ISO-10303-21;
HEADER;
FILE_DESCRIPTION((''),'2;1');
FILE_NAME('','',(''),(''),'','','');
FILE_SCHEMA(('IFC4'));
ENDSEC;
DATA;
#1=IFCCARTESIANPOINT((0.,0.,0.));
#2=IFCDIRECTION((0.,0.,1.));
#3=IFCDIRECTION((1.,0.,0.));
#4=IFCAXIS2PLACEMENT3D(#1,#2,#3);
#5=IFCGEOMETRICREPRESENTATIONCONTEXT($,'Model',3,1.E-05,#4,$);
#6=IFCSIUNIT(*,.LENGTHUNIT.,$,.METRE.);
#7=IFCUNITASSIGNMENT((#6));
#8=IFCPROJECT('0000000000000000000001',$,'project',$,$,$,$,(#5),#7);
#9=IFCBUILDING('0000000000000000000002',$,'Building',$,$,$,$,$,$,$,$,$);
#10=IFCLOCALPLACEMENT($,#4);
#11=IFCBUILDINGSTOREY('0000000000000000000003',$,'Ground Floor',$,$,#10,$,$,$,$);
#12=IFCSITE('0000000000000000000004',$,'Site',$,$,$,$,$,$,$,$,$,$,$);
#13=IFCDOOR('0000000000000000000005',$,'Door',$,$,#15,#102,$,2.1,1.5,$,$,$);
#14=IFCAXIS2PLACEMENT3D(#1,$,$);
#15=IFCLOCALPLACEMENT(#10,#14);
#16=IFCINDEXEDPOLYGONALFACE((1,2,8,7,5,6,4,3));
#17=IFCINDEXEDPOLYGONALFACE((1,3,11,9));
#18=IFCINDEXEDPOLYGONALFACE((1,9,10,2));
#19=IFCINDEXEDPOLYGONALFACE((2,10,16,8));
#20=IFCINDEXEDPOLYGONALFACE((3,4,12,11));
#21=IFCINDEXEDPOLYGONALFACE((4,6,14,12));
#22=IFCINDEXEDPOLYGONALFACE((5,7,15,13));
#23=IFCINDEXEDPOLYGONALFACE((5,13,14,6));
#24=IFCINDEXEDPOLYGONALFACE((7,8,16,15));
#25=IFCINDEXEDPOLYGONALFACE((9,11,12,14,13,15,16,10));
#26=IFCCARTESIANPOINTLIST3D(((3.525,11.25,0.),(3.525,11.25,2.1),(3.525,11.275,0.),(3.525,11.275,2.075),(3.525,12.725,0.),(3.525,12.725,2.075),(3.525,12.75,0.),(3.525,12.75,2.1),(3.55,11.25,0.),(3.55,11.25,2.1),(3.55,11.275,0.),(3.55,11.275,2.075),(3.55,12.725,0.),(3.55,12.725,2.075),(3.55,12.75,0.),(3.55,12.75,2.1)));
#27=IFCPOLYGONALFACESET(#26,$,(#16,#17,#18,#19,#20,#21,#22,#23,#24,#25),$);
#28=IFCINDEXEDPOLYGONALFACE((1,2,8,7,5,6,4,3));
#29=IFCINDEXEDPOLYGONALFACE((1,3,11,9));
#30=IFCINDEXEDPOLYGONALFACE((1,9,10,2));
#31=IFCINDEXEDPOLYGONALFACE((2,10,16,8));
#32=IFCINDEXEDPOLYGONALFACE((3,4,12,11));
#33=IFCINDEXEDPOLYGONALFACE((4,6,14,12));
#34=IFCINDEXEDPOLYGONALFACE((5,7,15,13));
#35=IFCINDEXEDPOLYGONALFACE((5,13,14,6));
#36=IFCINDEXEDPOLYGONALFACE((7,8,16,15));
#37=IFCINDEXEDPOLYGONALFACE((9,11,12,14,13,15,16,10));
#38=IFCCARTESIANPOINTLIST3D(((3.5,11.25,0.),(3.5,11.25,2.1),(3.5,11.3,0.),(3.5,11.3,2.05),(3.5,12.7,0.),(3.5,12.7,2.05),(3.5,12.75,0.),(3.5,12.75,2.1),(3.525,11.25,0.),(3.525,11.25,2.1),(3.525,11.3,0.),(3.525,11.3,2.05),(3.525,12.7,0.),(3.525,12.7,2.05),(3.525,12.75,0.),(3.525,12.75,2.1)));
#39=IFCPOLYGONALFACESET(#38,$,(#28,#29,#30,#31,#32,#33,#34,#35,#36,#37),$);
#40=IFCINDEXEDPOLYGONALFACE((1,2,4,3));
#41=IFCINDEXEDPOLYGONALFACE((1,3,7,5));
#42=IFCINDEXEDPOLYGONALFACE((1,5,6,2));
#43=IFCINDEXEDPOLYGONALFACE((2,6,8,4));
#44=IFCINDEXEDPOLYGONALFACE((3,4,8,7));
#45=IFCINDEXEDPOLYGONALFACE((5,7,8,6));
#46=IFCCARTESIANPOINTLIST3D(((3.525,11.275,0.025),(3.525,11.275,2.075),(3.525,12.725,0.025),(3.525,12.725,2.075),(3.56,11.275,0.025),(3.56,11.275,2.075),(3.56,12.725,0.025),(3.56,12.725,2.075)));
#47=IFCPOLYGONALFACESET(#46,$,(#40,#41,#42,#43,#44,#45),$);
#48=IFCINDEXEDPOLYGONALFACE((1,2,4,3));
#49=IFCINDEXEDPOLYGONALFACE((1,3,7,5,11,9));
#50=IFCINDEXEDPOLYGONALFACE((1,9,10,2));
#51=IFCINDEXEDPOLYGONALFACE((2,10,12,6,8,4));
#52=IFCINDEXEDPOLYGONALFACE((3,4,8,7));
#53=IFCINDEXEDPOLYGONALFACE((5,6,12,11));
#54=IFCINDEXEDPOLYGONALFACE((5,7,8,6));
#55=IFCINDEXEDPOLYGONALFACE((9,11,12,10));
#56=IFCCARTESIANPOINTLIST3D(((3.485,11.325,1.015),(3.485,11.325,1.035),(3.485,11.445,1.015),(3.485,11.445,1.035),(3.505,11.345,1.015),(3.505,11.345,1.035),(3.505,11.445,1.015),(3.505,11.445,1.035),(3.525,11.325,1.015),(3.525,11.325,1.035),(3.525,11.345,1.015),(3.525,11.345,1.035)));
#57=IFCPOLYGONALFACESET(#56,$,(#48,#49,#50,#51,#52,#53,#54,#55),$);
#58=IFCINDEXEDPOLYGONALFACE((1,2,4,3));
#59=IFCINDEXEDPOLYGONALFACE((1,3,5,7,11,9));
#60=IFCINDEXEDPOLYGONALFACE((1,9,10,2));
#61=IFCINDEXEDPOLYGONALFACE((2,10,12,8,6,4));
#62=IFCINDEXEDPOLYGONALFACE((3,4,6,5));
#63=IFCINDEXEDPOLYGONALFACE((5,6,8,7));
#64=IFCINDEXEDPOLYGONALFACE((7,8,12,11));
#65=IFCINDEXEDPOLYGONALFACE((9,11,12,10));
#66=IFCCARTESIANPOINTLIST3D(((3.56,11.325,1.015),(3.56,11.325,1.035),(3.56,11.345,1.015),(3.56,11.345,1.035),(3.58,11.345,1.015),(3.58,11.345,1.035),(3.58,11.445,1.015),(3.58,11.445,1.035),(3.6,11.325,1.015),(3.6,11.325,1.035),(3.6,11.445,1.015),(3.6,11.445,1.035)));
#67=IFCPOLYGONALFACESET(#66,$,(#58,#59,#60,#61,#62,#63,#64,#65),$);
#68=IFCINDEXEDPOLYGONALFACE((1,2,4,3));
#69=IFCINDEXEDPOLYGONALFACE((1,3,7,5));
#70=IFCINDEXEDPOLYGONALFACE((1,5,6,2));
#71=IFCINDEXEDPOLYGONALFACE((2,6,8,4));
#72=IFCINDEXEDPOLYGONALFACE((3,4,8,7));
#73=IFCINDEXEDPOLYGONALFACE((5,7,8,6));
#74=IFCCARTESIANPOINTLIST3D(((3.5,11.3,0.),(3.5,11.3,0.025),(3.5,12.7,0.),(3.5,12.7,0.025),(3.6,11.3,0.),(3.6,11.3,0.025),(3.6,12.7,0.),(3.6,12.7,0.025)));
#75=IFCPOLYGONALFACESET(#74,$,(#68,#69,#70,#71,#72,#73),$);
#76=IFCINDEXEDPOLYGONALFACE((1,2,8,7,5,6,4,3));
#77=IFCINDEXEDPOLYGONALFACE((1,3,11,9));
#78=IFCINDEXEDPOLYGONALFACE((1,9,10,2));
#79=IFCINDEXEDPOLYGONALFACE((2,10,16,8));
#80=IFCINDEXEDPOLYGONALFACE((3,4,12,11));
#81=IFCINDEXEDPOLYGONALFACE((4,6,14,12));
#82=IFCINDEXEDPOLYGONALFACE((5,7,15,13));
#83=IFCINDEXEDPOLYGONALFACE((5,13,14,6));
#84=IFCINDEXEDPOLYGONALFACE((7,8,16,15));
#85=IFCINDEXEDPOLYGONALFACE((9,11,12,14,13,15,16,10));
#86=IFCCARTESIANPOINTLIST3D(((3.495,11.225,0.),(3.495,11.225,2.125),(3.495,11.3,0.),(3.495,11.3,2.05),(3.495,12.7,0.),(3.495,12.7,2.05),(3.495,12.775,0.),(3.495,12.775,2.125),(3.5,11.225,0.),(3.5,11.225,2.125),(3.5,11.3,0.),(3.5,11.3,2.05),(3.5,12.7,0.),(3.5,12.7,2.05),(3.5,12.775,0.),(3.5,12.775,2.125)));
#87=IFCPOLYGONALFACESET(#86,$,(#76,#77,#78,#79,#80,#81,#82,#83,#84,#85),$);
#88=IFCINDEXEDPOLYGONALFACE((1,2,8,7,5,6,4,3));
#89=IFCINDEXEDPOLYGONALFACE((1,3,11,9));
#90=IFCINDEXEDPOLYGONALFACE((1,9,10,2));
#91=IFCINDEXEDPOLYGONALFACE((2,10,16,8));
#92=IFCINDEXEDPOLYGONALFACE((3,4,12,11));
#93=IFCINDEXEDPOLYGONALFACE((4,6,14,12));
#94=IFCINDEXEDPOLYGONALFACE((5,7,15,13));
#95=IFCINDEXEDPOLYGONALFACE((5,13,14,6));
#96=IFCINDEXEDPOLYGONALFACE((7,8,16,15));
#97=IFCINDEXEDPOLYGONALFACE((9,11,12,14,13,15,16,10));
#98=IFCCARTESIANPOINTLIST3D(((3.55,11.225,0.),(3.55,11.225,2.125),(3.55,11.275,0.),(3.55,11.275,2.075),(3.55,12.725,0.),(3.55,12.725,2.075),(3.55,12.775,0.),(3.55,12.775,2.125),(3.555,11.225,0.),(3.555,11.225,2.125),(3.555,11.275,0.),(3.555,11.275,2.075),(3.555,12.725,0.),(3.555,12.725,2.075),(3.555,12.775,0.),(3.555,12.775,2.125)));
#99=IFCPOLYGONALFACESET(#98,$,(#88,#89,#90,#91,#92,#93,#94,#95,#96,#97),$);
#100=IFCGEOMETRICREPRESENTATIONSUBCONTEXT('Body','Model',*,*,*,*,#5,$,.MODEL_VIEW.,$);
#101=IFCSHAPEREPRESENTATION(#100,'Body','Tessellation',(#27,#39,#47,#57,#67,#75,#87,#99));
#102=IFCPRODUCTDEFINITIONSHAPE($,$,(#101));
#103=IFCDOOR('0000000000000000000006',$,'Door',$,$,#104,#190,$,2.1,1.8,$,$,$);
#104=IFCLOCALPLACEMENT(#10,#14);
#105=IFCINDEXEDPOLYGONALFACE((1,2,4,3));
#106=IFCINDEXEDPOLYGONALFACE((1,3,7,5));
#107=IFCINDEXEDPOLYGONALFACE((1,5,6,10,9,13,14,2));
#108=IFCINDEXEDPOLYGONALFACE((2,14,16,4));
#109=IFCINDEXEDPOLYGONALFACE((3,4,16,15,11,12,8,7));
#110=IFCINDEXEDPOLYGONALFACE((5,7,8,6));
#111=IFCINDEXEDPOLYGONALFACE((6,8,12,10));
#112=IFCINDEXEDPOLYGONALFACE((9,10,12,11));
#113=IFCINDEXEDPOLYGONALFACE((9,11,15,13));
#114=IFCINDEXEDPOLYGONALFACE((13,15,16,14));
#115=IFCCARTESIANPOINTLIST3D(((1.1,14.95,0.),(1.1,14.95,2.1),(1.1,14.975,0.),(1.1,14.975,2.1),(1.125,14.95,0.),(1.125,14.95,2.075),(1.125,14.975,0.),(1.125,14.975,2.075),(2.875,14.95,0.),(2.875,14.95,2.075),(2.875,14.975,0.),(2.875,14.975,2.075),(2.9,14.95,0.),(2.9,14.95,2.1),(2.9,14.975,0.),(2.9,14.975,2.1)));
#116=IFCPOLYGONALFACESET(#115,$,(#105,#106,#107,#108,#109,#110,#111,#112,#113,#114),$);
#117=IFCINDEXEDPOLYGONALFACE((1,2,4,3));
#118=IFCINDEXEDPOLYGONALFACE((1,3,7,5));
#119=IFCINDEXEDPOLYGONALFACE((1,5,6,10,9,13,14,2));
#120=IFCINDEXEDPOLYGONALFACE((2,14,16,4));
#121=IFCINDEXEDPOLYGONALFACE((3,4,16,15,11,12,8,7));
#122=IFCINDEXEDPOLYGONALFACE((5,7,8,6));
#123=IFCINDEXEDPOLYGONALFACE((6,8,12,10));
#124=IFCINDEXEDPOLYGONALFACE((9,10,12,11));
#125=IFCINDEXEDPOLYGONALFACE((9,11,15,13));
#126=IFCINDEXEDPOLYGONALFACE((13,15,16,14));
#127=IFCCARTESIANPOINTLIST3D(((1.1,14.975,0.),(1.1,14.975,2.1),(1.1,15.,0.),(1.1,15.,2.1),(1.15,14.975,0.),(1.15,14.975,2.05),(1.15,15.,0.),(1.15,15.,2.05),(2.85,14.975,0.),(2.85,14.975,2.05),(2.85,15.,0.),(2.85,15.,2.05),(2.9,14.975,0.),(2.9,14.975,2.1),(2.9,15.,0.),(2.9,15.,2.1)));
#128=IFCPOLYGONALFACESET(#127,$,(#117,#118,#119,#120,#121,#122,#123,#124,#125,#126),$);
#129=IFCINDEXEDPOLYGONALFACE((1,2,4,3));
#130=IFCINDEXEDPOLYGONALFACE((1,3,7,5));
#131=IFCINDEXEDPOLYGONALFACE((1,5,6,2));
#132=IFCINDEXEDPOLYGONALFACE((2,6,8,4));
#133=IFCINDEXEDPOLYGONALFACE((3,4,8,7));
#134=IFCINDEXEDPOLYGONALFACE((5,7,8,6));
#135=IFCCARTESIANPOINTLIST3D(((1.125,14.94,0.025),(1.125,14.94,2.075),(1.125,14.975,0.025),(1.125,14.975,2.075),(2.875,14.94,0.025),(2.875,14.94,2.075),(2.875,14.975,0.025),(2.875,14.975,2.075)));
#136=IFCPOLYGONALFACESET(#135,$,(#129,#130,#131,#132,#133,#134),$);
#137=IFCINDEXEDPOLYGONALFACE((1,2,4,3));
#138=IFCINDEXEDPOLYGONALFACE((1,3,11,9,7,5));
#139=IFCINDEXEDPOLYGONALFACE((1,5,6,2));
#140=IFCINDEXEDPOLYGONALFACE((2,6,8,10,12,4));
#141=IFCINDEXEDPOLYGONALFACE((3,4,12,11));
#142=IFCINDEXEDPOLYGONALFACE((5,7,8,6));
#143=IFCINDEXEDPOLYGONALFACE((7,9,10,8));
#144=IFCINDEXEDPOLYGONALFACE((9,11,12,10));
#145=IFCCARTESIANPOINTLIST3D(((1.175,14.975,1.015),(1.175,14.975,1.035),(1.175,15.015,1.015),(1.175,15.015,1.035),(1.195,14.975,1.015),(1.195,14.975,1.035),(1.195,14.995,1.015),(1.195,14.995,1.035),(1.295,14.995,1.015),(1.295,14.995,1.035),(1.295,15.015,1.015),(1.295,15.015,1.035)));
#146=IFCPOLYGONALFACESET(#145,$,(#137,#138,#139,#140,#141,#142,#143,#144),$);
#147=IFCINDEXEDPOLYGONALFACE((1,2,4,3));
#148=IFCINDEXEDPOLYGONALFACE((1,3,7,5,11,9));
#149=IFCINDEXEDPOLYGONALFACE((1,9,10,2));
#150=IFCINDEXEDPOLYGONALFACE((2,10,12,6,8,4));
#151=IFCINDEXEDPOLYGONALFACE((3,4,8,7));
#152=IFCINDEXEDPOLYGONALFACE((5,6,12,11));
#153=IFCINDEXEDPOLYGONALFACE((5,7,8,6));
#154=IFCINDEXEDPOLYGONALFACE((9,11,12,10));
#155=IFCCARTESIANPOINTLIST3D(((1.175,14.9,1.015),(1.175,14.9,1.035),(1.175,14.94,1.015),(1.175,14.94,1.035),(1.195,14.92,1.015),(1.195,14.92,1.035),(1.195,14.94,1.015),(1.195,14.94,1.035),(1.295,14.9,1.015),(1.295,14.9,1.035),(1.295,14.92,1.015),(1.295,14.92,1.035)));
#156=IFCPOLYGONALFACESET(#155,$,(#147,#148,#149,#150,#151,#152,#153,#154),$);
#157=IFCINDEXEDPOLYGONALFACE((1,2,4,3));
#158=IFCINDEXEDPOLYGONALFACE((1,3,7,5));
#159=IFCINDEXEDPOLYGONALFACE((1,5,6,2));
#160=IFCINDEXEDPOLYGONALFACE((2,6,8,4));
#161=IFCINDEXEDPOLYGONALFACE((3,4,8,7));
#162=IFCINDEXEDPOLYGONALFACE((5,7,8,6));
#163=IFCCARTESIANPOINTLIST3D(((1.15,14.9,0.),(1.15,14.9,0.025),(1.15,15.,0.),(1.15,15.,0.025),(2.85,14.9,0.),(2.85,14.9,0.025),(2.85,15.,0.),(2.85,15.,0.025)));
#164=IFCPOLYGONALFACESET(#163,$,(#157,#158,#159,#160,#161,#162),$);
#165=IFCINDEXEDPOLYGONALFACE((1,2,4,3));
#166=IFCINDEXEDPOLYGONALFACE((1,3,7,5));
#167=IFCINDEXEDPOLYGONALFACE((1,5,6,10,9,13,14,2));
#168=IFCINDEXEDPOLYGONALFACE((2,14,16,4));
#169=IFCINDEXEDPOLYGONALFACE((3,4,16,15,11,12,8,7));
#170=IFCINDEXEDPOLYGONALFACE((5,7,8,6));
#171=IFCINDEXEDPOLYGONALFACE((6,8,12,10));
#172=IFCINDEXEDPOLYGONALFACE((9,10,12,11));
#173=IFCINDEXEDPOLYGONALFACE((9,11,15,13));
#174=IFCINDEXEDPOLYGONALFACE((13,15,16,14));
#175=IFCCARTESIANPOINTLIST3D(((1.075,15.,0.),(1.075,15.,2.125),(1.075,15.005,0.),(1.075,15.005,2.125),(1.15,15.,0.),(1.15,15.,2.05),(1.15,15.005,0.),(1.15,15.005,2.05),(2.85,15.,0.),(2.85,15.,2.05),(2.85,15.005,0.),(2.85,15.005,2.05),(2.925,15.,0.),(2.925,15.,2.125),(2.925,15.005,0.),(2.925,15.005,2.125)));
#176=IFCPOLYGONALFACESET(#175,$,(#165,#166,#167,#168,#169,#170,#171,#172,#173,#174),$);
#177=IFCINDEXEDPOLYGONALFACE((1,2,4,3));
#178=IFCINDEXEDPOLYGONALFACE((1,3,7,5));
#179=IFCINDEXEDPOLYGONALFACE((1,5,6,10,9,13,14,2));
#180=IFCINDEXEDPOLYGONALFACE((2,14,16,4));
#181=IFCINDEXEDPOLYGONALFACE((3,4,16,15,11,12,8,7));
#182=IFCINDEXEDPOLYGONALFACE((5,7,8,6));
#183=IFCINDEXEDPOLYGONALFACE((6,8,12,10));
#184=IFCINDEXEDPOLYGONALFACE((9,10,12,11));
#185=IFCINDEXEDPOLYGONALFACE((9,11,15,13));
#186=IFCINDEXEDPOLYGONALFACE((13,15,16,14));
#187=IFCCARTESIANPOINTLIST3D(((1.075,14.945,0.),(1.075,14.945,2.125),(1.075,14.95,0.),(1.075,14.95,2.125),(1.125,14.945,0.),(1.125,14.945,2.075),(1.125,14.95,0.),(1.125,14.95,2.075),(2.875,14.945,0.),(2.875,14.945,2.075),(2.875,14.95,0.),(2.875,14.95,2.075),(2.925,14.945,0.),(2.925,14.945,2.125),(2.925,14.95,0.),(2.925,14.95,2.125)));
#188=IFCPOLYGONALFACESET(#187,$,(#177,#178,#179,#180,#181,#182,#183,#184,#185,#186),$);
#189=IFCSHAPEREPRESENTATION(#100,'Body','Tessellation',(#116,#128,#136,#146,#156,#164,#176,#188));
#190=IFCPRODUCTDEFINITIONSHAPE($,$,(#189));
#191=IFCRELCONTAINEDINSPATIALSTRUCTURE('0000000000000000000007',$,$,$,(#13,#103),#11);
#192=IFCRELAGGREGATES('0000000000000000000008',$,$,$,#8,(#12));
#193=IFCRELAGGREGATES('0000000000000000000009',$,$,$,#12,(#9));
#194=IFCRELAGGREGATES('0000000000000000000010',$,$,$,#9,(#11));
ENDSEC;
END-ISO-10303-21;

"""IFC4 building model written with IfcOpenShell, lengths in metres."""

from ifc_helpers import new_model, si_unit, frame, origin_with_axes, place, context, subcontext, project, spatial, line, indexed_curve, outline, extrude, element, save


model = new_model("IFC4")

# Units and contexts
model_context = context("Model", 3, precision=1e-05, world=origin_with_axes())
body_context = subcontext(model_context, "Body", "Model", "MODEL_VIEW")
ifc_project = project(units=[si_unit("LENGTHUNIT", "METRE")], contexts=[model_context])

# Site, building, storey
site = spatial("IfcSite", under=ifc_project, Name="Site")
building = spatial("IfcBuilding", under=site, Name="Building")
storey_placement = place(None, origin_with_axes())
storey = spatial("IfcBuildingStorey", under=building, at=storey_placement, Name="Ground Floor")

# Doors
door_1_placement = place(storey_placement, frame((3.5, 12.75, 0.0), z_axis=(0.0, 0.0, 1.0), x_axis=(0.0, -1.0, 0.0)))
element("IfcDoor", 1, at=door_1_placement, inside=storey, Name="Door", OverallHeight=2.1, OverallWidth=1.5, context=body_context, shape_type="SweptSolid", body=[
    extrude(outline(indexed_curve([(0.0, 0.0), (0.0, 2.1), (1.5, 2.1), (1.5, 0.0), (1.475, 0.0), (1.475, 2.075), (0.025, 2.075), (0.025, 0.0)], segments=[line(1, 2, 3, 4, 5, 6, 7, 8, 1)])), frame((0.0, 0.025, 0.0), z_axis=(0.0, -1.0, 0.0), x_axis=(1.0, 0.0, 0.0)), (0.0, 0.0, -1.0), 0.025),
    extrude(outline(indexed_curve([(0.0, 0.0), (0.0, 2.1), (1.5, 2.1), (1.5, 0.0), (1.45, 0.0), (1.45, 2.05), (0.05, 2.05), (0.05, 0.0)], segments=[line(1, 2, 3, 4, 5, 6, 7, 8, 1)])), frame((0.0, 0.0, 0.0), z_axis=(0.0, -1.0, 0.0), x_axis=(1.0, 0.0, 0.0)), (0.0, 0.0, -1.0), 0.025),
    extrude(outline(indexed_curve([(0.0, 0.0), (1.45, 0.0), (1.45, 0.035), (0.0, 0.035)], segments=[line(1, 2, 3, 4, 1)])), frame((0.025, 0.025, 0.025), z_axis=(0.0, 0.0, 1.0), x_axis=(1.0, 0.0, 0.0)), (0.0, 0.0, 1.0), 2.05),
    extrude(outline(indexed_curve([(0.0, 0.0), (0.0, -0.04), (-0.12, -0.04), (-0.12, -0.02), (-0.02, -0.02), (-0.02, 0.0)], segments=[line(1, 2, 3, 4, 5, 6, 1)])), frame((1.425, 0.025, 1.015), z_axis=(0.0, 0.0, 1.0), x_axis=(1.0, 0.0, 0.0)), (0.0, 0.0, 1.0), 0.02),
    extrude(outline(indexed_curve([(0.0, 0.0), (0.0, 0.04), (-0.12, 0.04), (-0.12, 0.02), (-0.02, 0.02), (-0.02, 0.0)], segments=[line(1, 2, 3, 4, 5, 6, 1)])), frame((1.425, 0.06, 1.015), z_axis=(0.0, 0.0, 1.0), x_axis=(1.0, 0.0, 0.0)), (0.0, 0.0, 1.0), 0.02),
    extrude(outline(indexed_curve([(0.0, 0.0), (1.4, 0.0), (1.4, 0.1), (0.0, 0.1)], segments=[line(1, 2, 3, 4, 1)])), frame((0.05, 0.0, 0.0), z_axis=(0.0, 0.0, 1.0), x_axis=(1.0, 0.0, 0.0)), (0.0, 0.0, 1.0), 0.025),
    extrude(outline(indexed_curve([(0.0, 0.0), (0.0, 2.125), (1.55, 2.125), (1.55, 0.0), (1.475, 0.0), (1.475, 2.05), (0.075, 2.05), (0.075, 0.0)], segments=[line(1, 2, 3, 4, 5, 6, 7, 8, 1)])), frame((-0.025, -0.005, 0.0), z_axis=(0.0, -1.0, 0.0), x_axis=(1.0, 0.0, 0.0)), (0.0, 0.0, -1.0), 0.005),
    extrude(outline(indexed_curve([(0.0, 0.0), (0.0, 2.125), (1.55, 2.125), (1.55, 0.0), (1.5, 0.0), (1.5, 2.075), (0.05, 2.075), (0.05, 0.0)], segments=[line(1, 2, 3, 4, 5, 6, 7, 8, 1)])), frame((-0.025, 0.05, 0.0), z_axis=(0.0, -1.0, 0.0), x_axis=(1.0, 0.0, 0.0)), (0.0, 0.0, -1.0), 0.005),
])
door_2_placement = place(storey_placement, frame((2.9, 15.0, 0.0), z_axis=(0.0, 0.0, 1.0), x_axis=(-1.0, 0.0, 0.0)))
element("IfcDoor", 2, at=door_2_placement, inside=storey, Name="Door", OverallHeight=2.1, OverallWidth=1.8, context=body_context, shape_type="SweptSolid", body=[
    extrude(outline(indexed_curve([(0.0, 0.0), (0.0, 2.1), (1.8, 2.1), (1.8, 0.0), (1.775, 0.0), (1.775, 2.075), (0.025, 2.075), (0.025, 0.0)], segments=[line(1, 2, 3, 4, 5, 6, 7, 8, 1)])), frame((0.0, 0.025, 0.0), z_axis=(0.0, -1.0, 0.0), x_axis=(1.0, 0.0, 0.0)), (0.0, 0.0, -1.0), 0.025),
    extrude(outline(indexed_curve([(0.0, 0.0), (0.0, 2.1), (1.8, 2.1), (1.8, 0.0), (1.75, 0.0), (1.75, 2.05), (0.05, 2.05), (0.05, 0.0)], segments=[line(1, 2, 3, 4, 5, 6, 7, 8, 1)])), frame((0.0, 0.0, 0.0), z_axis=(0.0, -1.0, 0.0), x_axis=(1.0, 0.0, 0.0)), (0.0, 0.0, -1.0), 0.025),
    extrude(outline(indexed_curve([(0.0, 0.0), (1.75, 0.0), (1.75, 0.035), (0.0, 0.035)], segments=[line(1, 2, 3, 4, 1)])), frame((0.025, 0.025, 0.025), z_axis=(0.0, 0.0, 1.0), x_axis=(1.0, 0.0, 0.0)), (0.0, 0.0, 1.0), 2.05),
    extrude(outline(indexed_curve([(0.0, 0.0), (0.0, -0.04), (-0.12, -0.04), (-0.12, -0.02), (-0.02, -0.02), (-0.02, 0.0)], segments=[line(1, 2, 3, 4, 5, 6, 1)])), frame((1.725, 0.025, 1.015), z_axis=(0.0, 0.0, 1.0), x_axis=(1.0, 0.0, 0.0)), (0.0, 0.0, 1.0), 0.02),
    extrude(outline(indexed_curve([(0.0, 0.0), (0.0, 0.04), (-0.12, 0.04), (-0.12, 0.02), (-0.02, 0.02), (-0.02, 0.0)], segments=[line(1, 2, 3, 4, 5, 6, 1)])), frame((1.725, 0.06, 1.015), z_axis=(0.0, 0.0, 1.0), x_axis=(1.0, 0.0, 0.0)), (0.0, 0.0, 1.0), 0.02),
    extrude(outline(indexed_curve([(0.0, 0.0), (1.7, 0.0), (1.7, 0.1), (0.0, 0.1)], segments=[line(1, 2, 3, 4, 1)])), frame((0.05, 0.0, 0.0), z_axis=(0.0, 0.0, 1.0), x_axis=(1.0, 0.0, 0.0)), (0.0, 0.0, 1.0), 0.025),
    extrude(outline(indexed_curve([(0.0, 0.0), (0.0, 2.125), (1.85, 2.125), (1.85, 0.0), (1.775, 0.0), (1.775, 2.05), (0.075, 2.05), (0.075, 0.0)], segments=[line(1, 2, 3, 4, 5, 6, 7, 8, 1)])), frame((-0.025, -0.005, 0.0), z_axis=(0.0, -1.0, 0.0), x_axis=(1.0, 0.0, 0.0)), (0.0, 0.0, -1.0), 0.005),
    extrude(outline(indexed_curve([(0.0, 0.0), (0.0, 2.125), (1.85, 2.125), (1.85, 0.0), (1.8, 0.0), (1.8, 2.075), (0.05, 2.075), (0.05, 0.0)], segments=[line(1, 2, 3, 4, 5, 6, 7, 8, 1)])), frame((-0.025, 0.05, 0.0), z_axis=(0.0, -1.0, 0.0), x_axis=(1.0, 0.0, 0.0)), (0.0, 0.0, -1.0), 0.005),
])

save(model, "model.ifc")
